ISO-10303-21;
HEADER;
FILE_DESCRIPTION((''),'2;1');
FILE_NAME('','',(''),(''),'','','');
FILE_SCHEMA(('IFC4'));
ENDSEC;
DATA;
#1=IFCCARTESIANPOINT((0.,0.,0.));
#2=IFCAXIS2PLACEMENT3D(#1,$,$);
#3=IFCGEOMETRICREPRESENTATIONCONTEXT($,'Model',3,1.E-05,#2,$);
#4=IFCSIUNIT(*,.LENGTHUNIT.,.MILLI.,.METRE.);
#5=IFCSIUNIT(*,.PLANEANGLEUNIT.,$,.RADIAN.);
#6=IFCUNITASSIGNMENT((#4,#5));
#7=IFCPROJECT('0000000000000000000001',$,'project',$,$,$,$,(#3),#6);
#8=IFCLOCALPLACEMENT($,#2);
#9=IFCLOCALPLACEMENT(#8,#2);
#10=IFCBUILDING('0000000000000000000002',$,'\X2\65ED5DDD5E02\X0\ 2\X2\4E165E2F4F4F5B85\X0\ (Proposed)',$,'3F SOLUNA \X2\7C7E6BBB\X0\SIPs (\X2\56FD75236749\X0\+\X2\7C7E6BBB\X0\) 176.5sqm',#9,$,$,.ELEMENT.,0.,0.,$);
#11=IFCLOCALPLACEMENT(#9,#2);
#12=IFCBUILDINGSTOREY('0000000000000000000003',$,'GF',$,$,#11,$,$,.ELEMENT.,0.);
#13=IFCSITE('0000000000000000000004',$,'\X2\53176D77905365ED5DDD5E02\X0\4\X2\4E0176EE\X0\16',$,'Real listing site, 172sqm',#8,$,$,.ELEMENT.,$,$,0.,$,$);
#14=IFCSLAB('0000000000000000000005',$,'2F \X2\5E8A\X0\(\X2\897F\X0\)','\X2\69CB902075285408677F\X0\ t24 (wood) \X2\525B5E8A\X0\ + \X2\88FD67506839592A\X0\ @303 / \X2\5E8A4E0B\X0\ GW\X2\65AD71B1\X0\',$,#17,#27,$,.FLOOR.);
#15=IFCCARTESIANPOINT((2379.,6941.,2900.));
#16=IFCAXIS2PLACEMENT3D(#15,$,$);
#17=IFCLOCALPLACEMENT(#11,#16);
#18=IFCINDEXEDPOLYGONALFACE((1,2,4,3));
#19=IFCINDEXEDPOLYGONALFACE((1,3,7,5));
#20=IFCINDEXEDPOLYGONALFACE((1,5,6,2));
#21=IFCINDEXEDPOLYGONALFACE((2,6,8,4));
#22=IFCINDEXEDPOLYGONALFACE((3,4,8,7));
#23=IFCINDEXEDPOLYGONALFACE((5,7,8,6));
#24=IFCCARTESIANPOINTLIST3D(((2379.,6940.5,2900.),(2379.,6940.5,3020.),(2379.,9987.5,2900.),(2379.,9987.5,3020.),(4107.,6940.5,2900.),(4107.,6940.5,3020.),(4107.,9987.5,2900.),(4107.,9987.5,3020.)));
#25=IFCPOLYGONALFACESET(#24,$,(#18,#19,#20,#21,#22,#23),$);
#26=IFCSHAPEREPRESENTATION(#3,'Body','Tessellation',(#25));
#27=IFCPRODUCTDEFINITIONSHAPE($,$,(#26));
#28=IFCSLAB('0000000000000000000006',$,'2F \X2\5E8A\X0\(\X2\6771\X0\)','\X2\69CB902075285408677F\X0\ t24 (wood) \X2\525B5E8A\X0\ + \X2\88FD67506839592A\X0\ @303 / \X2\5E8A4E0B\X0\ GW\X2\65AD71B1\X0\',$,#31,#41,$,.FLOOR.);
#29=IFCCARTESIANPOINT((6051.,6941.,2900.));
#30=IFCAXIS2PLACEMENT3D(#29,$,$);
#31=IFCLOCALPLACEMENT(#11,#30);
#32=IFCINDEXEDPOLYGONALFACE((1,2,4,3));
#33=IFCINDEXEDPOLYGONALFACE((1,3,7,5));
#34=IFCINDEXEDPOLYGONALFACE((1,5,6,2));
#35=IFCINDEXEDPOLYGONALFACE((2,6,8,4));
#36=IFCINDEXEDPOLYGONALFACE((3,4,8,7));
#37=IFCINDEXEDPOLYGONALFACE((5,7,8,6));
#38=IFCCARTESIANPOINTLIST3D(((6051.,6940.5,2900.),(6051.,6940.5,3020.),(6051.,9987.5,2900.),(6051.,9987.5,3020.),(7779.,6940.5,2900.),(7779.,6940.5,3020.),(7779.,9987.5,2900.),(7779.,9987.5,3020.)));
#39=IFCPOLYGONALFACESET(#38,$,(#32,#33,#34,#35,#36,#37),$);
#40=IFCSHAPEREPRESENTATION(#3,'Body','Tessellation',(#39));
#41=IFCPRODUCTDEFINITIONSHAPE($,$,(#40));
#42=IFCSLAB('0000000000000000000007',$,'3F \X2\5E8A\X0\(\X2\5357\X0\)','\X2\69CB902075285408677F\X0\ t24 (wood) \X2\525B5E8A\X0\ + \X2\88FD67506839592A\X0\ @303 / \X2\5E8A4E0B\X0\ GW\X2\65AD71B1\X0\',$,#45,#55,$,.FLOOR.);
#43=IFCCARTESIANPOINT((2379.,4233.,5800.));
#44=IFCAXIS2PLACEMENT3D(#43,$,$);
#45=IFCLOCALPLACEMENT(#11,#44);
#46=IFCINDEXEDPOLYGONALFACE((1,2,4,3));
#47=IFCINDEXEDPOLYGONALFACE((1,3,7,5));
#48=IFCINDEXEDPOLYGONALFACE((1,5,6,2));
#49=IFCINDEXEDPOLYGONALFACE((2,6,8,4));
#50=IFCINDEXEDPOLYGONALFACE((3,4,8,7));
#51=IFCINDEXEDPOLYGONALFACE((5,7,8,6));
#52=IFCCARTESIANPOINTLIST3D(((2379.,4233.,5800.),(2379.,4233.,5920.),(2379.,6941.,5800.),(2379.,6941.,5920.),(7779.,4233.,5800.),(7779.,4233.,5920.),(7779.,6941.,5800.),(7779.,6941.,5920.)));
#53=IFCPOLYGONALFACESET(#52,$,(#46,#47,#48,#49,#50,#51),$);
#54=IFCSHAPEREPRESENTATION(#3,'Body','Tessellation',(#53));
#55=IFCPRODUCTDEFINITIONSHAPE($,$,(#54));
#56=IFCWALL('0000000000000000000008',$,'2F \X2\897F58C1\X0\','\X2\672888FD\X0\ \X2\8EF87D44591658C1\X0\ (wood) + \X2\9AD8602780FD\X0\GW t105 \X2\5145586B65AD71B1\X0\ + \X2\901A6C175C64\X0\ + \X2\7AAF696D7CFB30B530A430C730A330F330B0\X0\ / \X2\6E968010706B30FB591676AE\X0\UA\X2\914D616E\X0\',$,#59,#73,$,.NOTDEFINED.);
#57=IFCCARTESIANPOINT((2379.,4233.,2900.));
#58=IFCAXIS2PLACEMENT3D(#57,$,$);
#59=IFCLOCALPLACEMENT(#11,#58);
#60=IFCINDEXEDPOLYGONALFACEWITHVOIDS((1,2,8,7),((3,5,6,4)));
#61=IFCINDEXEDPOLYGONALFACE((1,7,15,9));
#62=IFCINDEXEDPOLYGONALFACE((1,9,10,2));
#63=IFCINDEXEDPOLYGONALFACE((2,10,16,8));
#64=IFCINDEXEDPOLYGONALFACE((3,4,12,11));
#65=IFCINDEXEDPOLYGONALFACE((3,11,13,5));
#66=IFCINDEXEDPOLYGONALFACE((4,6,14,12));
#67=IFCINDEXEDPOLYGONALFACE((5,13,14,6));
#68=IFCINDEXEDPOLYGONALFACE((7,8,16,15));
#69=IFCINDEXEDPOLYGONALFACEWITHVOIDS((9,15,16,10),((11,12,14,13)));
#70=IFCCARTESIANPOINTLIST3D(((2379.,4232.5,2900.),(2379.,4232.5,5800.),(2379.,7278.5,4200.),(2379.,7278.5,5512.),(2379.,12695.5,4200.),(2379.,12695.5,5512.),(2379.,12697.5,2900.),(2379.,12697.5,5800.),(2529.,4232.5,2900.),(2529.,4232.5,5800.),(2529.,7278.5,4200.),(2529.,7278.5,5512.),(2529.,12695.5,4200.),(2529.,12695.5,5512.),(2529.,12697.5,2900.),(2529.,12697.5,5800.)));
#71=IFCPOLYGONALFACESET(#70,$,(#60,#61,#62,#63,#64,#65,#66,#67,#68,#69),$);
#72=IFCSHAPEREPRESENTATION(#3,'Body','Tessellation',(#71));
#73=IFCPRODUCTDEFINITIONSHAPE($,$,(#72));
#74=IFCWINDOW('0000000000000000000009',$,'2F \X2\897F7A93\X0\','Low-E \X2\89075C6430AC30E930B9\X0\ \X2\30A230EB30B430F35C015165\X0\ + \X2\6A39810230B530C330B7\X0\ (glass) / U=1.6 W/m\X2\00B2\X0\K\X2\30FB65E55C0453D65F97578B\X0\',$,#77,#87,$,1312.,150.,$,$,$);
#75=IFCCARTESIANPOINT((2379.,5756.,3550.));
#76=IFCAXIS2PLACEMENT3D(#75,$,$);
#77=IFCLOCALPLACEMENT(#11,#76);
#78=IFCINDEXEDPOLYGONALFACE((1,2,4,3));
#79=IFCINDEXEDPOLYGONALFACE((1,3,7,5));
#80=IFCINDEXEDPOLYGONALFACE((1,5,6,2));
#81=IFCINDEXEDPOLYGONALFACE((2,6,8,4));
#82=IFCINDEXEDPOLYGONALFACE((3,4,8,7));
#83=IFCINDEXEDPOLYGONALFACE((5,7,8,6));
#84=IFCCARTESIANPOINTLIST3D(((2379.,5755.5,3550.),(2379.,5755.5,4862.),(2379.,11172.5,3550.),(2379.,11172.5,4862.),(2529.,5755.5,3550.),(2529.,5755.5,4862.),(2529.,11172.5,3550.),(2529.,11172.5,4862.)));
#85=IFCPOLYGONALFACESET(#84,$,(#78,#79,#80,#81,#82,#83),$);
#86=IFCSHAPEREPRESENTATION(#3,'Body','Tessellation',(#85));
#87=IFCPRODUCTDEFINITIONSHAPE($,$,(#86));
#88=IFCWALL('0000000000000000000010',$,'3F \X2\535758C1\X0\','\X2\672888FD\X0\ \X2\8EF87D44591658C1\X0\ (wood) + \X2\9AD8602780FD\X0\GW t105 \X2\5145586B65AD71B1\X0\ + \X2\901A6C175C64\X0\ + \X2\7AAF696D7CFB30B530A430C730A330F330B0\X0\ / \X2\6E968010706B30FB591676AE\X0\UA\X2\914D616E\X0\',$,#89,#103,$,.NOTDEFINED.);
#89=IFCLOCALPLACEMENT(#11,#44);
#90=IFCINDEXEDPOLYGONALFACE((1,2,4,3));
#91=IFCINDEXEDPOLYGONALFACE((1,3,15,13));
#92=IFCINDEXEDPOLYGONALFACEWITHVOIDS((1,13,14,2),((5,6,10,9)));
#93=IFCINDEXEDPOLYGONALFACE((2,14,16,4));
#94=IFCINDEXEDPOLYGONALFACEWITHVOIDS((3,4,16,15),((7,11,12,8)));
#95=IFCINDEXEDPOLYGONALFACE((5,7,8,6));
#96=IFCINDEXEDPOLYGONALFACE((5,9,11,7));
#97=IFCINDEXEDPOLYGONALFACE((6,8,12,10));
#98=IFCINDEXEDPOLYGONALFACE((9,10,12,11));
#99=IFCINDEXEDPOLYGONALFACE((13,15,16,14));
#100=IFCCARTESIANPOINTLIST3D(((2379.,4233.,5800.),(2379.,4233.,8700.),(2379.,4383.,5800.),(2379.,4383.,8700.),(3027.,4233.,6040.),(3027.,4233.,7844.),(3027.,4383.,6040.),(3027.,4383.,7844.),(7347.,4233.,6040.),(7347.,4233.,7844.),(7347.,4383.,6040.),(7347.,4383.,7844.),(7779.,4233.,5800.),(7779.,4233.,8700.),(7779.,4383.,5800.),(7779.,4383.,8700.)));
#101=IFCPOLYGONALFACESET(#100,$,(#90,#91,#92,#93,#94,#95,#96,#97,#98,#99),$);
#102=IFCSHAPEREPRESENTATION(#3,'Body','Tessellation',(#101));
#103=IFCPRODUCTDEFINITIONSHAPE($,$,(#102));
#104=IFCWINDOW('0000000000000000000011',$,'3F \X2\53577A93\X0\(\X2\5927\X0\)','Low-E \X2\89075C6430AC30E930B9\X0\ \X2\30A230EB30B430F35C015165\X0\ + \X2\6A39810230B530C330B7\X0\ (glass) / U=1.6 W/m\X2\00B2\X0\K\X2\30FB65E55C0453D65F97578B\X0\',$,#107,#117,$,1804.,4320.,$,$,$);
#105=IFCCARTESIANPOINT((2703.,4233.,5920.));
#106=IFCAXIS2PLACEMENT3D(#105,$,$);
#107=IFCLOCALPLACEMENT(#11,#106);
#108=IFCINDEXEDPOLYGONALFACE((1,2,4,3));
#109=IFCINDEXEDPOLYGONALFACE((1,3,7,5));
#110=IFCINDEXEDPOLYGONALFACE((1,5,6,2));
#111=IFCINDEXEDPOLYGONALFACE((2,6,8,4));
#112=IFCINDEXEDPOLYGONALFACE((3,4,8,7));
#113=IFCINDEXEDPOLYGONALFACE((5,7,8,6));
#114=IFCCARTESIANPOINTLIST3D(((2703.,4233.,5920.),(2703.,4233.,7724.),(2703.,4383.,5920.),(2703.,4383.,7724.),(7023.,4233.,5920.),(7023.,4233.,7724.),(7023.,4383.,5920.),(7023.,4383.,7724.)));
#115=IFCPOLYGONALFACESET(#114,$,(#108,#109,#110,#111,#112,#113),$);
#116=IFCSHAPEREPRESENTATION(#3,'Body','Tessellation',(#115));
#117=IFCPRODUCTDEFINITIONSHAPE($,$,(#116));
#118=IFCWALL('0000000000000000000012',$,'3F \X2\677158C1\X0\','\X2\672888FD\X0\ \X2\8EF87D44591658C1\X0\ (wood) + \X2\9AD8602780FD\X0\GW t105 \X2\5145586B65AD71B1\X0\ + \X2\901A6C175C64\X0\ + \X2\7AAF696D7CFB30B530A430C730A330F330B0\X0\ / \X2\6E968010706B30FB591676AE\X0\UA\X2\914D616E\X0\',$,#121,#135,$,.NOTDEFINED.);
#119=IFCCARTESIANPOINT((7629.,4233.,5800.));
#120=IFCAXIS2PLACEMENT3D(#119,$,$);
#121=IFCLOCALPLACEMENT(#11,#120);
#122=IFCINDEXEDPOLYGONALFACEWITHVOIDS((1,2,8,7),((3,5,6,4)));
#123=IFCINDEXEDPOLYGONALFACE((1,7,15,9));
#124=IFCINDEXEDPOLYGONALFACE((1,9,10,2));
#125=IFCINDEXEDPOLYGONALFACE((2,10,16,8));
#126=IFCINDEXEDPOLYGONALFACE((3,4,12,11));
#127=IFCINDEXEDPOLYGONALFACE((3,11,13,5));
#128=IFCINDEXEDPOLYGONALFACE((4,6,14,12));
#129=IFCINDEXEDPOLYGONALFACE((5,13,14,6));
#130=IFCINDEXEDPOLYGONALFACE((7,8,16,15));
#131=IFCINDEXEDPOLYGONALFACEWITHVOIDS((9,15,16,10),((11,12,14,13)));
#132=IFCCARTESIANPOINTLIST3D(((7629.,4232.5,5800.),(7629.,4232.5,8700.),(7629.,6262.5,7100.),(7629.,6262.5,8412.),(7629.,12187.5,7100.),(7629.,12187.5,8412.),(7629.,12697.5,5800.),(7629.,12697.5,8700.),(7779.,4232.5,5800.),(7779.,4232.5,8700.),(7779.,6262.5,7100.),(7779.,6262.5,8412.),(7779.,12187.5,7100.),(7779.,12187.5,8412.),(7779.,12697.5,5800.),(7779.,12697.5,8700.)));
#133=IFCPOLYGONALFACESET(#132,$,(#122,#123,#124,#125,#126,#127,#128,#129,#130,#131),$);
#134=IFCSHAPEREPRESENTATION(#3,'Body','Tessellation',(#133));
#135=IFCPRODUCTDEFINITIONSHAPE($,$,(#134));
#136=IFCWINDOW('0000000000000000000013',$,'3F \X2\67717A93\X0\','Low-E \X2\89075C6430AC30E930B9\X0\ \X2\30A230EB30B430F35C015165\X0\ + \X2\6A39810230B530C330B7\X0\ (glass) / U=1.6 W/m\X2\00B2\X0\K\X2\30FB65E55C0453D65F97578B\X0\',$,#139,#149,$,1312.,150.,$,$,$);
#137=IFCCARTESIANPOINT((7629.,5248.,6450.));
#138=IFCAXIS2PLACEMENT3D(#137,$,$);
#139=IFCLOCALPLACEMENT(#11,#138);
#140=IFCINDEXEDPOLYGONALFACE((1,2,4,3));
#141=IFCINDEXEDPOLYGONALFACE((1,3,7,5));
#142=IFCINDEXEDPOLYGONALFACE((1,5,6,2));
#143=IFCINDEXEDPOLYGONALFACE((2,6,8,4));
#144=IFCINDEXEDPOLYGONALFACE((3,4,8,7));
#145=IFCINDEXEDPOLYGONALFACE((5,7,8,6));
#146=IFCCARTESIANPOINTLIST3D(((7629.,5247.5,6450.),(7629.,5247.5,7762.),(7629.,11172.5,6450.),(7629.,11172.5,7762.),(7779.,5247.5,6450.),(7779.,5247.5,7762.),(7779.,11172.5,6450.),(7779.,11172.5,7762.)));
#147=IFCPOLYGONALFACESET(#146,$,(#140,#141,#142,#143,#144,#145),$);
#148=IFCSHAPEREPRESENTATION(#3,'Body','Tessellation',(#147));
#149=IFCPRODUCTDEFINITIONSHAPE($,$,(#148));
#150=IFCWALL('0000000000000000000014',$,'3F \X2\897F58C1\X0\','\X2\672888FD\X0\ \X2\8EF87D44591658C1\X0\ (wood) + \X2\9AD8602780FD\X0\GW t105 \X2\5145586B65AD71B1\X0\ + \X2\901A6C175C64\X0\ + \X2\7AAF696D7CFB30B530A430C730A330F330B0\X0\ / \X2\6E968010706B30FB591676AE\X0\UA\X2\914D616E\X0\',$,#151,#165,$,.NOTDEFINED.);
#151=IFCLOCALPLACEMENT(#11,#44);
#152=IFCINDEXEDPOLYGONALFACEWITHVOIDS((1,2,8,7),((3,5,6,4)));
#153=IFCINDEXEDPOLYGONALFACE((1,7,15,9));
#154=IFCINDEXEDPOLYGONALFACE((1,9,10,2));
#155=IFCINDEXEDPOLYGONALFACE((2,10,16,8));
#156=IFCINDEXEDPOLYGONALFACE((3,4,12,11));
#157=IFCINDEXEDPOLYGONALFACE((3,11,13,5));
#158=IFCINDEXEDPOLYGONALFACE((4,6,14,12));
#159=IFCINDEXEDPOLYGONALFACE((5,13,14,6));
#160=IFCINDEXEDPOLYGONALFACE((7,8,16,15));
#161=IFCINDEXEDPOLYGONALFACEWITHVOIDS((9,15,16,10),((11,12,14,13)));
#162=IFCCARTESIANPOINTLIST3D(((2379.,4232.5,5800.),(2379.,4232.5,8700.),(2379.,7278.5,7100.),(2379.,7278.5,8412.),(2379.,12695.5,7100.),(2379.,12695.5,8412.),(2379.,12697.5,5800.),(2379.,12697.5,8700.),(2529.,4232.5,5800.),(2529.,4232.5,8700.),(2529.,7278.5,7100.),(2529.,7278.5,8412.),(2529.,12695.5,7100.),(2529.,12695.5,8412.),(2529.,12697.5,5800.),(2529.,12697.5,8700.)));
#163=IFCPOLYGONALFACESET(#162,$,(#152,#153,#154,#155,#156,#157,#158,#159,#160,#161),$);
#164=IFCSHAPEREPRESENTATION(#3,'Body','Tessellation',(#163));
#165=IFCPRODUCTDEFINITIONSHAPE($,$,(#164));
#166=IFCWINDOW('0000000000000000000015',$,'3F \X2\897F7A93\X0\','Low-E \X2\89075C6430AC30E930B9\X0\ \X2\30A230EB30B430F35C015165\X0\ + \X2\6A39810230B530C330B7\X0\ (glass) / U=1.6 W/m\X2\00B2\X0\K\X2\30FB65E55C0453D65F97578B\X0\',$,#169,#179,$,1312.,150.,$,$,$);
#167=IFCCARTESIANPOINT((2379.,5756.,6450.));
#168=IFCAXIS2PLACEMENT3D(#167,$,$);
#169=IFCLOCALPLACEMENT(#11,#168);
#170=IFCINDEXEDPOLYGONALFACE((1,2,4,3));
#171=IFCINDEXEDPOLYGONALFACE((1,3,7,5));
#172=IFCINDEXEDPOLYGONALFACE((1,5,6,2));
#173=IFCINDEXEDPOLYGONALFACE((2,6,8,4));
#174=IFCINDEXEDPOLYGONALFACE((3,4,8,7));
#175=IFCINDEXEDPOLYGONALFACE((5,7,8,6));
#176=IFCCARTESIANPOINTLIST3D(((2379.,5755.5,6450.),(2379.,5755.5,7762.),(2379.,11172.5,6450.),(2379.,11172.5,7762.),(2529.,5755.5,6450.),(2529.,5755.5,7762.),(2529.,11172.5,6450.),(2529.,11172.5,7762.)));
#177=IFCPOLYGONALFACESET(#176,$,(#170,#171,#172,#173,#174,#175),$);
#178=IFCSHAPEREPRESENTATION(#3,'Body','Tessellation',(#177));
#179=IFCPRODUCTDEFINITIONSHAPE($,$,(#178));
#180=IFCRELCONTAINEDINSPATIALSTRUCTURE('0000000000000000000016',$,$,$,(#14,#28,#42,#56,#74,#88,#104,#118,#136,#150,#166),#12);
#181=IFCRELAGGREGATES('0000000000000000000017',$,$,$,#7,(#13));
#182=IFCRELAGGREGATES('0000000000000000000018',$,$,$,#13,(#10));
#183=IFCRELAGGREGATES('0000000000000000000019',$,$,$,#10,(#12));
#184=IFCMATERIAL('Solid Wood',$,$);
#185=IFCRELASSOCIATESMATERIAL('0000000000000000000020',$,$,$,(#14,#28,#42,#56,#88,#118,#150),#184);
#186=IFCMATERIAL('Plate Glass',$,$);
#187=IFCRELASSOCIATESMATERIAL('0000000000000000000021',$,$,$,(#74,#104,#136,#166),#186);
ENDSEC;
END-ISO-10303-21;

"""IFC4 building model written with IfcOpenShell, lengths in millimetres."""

from ifc_helpers import new_model, si_unit, frame, frame_2d, origin, place, context, project, spatial, rectangle, extrude, material, element, fill, save


model = new_model("IFC4")

# Units and contexts
model_context = context("Model", 3, precision=1e-05, world=origin())
ifc_project = project(units=[si_unit("LENGTHUNIT", "METRE", prefix="MILLI"), si_unit("PLANEANGLEUNIT", "RADIAN")], contexts=[model_context])

# Site, building, storey
site_placement = place(None, origin())
site = spatial("IfcSite", under=ifc_project, at=site_placement, Name="北海道旭川市4丁目16", ObjectType="Real listing site, 172sqm", CompositionType="ELEMENT", RefElevation=0.0)
building_placement = place(site_placement, origin())
building = spatial("IfcBuilding", under=site, at=building_placement, Name="旭川市 2世帯住宅 (Proposed)", ObjectType="3F SOLUNA 籾殻SIPs (国産杉+籾殻) 176.5sqm", CompositionType="ELEMENT", ElevationOfRefHeight=0.0, ElevationOfTerrain=0.0)
storey_placement = place(building_placement, origin())
storey = spatial("IfcBuildingStorey", under=building, at=storey_placement, Name="GF", CompositionType="ELEMENT", Elevation=0.0)

# Slabs
ifc_material_1 = material(Name="Solid Wood")
slab_1_placement = place(storey_placement, frame((2379.0, 6941.0, 2900.0)))
element("IfcSlab", 1, at=slab_1_placement, inside=storey, material=ifc_material_1, Name="2F 床(西)", Description="構造用合板 t24 (wood) 剛床 + 製材根太 @303 / 床下 GW断熱", PredefinedType="FLOOR", context=model_context, shape_type="SweptSolid", body=[
    extrude(rectangle(XDim=1728.0, YDim=3047.0, at=frame_2d((864.0, 1523.0))), frame((2379.0, 6941.0, 2900.0)), (0.0, 0.0, 1.0), 120.0),
])
slab_2_placement = place(storey_placement, frame((6051.0, 6941.0, 2900.0)))
element("IfcSlab", 2, at=slab_2_placement, inside=storey, material=ifc_material_1, Name="2F 床(東)", Description="構造用合板 t24 (wood) 剛床 + 製材根太 @303 / 床下 GW断熱", PredefinedType="FLOOR", context=model_context, shape_type="SweptSolid", body=[
    extrude(rectangle(XDim=1728.0, YDim=3047.0, at=frame_2d((864.0, 1523.0))), frame((6051.0, 6941.0, 2900.0)), (0.0, 0.0, 1.0), 120.0),
])
slab_3_placement = place(storey_placement, frame((2379.0, 4233.0, 5800.0)))
element("IfcSlab", 3, at=slab_3_placement, inside=storey, material=ifc_material_1, Name="3F 床(南)", Description="構造用合板 t24 (wood) 剛床 + 製材根太 @303 / 床下 GW断熱", PredefinedType="FLOOR", context=model_context, shape_type="SweptSolid", body=[
    extrude(rectangle(XDim=5400.0, YDim=2708.0, at=frame_2d((2700.0, 1354.0))), frame((2379.0, 4233.0, 5800.0)), (0.0, 0.0, 1.0), 120.0),
])

# Walls, openings, windows
wall_1_placement = place(storey_placement, frame((2379.0, 4233.0, 2900.0)))
wall_1 = element("IfcWall", 4, at=wall_1_placement, inside=storey, material=ifc_material_1, Name="2F 西壁", Description="木製 軸組外壁 (wood) + 高性能GW t105 充填断熱 + 通気層 + 窯業系サイディング / 準耐火・外皮UA配慮", PredefinedType="NOTDEFINED", context=model_context, shape_type="SweptSolid", body=[
    extrude(rectangle(XDim=150.0, YDim=8465.0, at=frame_2d((75.0, 4232.0))), frame((2379.0, 4233.0, 2900.0)), (0.0, 0.0, 1.0), 2900.0),
])
opening_1_placement = place(storey_placement, frame((2379.0, 5756.0, 3550.0)))
opening_1 = element("IfcOpeningElement", 5, at=opening_1_placement, cuts=wall_1, PredefinedType="NOTDEFINED", context=model_context, shape_type="SweptSolid", body=[
    extrude(rectangle(XDim=150.0, YDim=5417.0, at=frame_2d((75.0, 2708.0))), frame((2379.0, 5756.0, 3550.0)), (0.0, 0.0, 1.0), 1312.0),
])
ifc_material_2 = material(Name="Plate Glass")
window_1_placement = place(storey_placement, frame((2379.0, 5756.0, 3550.0)))
window_1 = element("IfcWindow", 6, at=window_1_placement, inside=storey, material=ifc_material_2, Name="2F 西窓", Description="Low-E 複層ガラス アルゴン封入 + 樹脂サッシ (glass) / U=1.6 W/m²K・日射取得型", OverallHeight=1312.0, OverallWidth=150.0, context=model_context, shape_type="SweptSolid", body=[
    extrude(rectangle(XDim=150.0, YDim=5417.0, at=frame_2d((75.0, 2708.0))), frame((2379.0, 5756.0, 3550.0)), (0.0, 0.0, 1.0), 1312.0),
])
fill(opening_1, window_1)
wall_2_placement = place(storey_placement, frame((2379.0, 4233.0, 5800.0)))
wall_2 = element("IfcWall", 7, at=wall_2_placement, inside=storey, material=ifc_material_1, Name="3F 南壁", Description="木製 軸組外壁 (wood) + 高性能GW t105 充填断熱 + 通気層 + 窯業系サイディング / 準耐火・外皮UA配慮", PredefinedType="NOTDEFINED", context=model_context, shape_type="SweptSolid", body=[
    extrude(rectangle(XDim=5400.0, YDim=150.0, at=frame_2d((2700.0, 75.0))), frame((2379.0, 4233.0, 5800.0)), (0.0, 0.0, 1.0), 2900.0),
])
opening_2_placement = place(storey_placement, frame((2703.0, 4233.0, 5920.0)))
opening_2 = element("IfcOpeningElement", 8, at=opening_2_placement, cuts=wall_2, PredefinedType="NOTDEFINED", context=model_context, shape_type="SweptSolid", body=[
    extrude(rectangle(XDim=4320.0, YDim=150.0, at=frame_2d((2160.0, 75.0))), frame((2703.0, 4233.0, 5920.0)), (0.0, 0.0, 1.0), 1804.0),
])
window_2_placement = place(storey_placement, frame((2703.0, 4233.0, 5920.0)))
window_2 = element("IfcWindow", 9, at=window_2_placement, inside=storey, material=ifc_material_2, Name="3F 南窓(大)", Description="Low-E 複層ガラス アルゴン封入 + 樹脂サッシ (glass) / U=1.6 W/m²K・日射取得型", OverallHeight=1804.0, OverallWidth=4320.0, context=model_context, shape_type="SweptSolid", body=[
    extrude(rectangle(XDim=4320.0, YDim=150.0, at=frame_2d((2160.0, 75.0))), frame((2703.0, 4233.0, 5920.0)), (0.0, 0.0, 1.0), 1804.0),
])
fill(opening_2, window_2)
wall_3_placement = place(storey_placement, frame((7629.0, 4233.0, 5800.0)))
wall_3 = element("IfcWall", 10, at=wall_3_placement, inside=storey, material=ifc_material_1, Name="3F 東壁", Description="木製 軸組外壁 (wood) + 高性能GW t105 充填断熱 + 通気層 + 窯業系サイディング / 準耐火・外皮UA配慮", PredefinedType="NOTDEFINED", context=model_context, shape_type="SweptSolid", body=[
    extrude(rectangle(XDim=150.0, YDim=8465.0, at=frame_2d((75.0, 4232.0))), frame((7629.0, 4233.0, 5800.0)), (0.0, 0.0, 1.0), 2900.0),
])
opening_3_placement = place(storey_placement, frame((7629.0, 5248.0, 6450.0)))
opening_3 = element("IfcOpeningElement", 11, at=opening_3_placement, cuts=wall_3, PredefinedType="NOTDEFINED", context=model_context, shape_type="SweptSolid", body=[
    extrude(rectangle(XDim=150.0, YDim=5925.0, at=frame_2d((75.0, 2962.0))), frame((7629.0, 5248.0, 6450.0)), (0.0, 0.0, 1.0), 1312.0),
])
window_3_placement = place(storey_placement, frame((7629.0, 5248.0, 6450.0)))
window_3 = element("IfcWindow", 12, at=window_3_placement, inside=storey, material=ifc_material_2, Name="3F 東窓", Description="Low-E 複層ガラス アルゴン封入 + 樹脂サッシ (glass) / U=1.6 W/m²K・日射取得型", OverallHeight=1312.0, OverallWidth=150.0, context=model_context, shape_type="SweptSolid", body=[
    extrude(rectangle(XDim=150.0, YDim=5925.0, at=frame_2d((75.0, 2962.0))), frame((7629.0, 5248.0, 6450.0)), (0.0, 0.0, 1.0), 1312.0),
])
fill(opening_3, window_3)
wall_4_placement = place(storey_placement, frame((2379.0, 4233.0, 5800.0)))
wall_4 = element("IfcWall", 13, at=wall_4_placement, inside=storey, material=ifc_material_1, Name="3F 西壁", Description="木製 軸組外壁 (wood) + 高性能GW t105 充填断熱 + 通気層 + 窯業系サイディング / 準耐火・外皮UA配慮", PredefinedType="NOTDEFINED", context=model_context, shape_type="SweptSolid", body=[
    extrude(rectangle(XDim=150.0, YDim=8465.0, at=frame_2d((75.0, 4232.0))), frame((2379.0, 4233.0, 5800.0)), (0.0, 0.0, 1.0), 2900.0),
])
opening_4_placement = place(storey_placement, frame((2379.0, 5756.0, 6450.0)))
opening_4 = element("IfcOpeningElement", 14, at=opening_4_placement, cuts=wall_4, PredefinedType="NOTDEFINED", context=model_context, shape_type="SweptSolid", body=[
    extrude(rectangle(XDim=150.0, YDim=5417.0, at=frame_2d((75.0, 2708.0))), frame((2379.0, 5756.0, 6450.0)), (0.0, 0.0, 1.0), 1312.0),
])
window_4_placement = place(storey_placement, frame((2379.0, 5756.0, 6450.0)))
window_4 = element("IfcWindow", 15, at=window_4_placement, inside=storey, material=ifc_material_2, Name="3F 西窓", Description="Low-E 複層ガラス アルゴン封入 + 樹脂サッシ (glass) / U=1.6 W/m²K・日射取得型", OverallHeight=1312.0, OverallWidth=150.0, context=model_context, shape_type="SweptSolid", body=[
    extrude(rectangle(XDim=150.0, YDim=5417.0, at=frame_2d((75.0, 2708.0))), frame((2379.0, 5756.0, 6450.0)), (0.0, 0.0, 1.0), 1312.0),
])
fill(opening_4, window_4)

save(model, "model.ifc")
